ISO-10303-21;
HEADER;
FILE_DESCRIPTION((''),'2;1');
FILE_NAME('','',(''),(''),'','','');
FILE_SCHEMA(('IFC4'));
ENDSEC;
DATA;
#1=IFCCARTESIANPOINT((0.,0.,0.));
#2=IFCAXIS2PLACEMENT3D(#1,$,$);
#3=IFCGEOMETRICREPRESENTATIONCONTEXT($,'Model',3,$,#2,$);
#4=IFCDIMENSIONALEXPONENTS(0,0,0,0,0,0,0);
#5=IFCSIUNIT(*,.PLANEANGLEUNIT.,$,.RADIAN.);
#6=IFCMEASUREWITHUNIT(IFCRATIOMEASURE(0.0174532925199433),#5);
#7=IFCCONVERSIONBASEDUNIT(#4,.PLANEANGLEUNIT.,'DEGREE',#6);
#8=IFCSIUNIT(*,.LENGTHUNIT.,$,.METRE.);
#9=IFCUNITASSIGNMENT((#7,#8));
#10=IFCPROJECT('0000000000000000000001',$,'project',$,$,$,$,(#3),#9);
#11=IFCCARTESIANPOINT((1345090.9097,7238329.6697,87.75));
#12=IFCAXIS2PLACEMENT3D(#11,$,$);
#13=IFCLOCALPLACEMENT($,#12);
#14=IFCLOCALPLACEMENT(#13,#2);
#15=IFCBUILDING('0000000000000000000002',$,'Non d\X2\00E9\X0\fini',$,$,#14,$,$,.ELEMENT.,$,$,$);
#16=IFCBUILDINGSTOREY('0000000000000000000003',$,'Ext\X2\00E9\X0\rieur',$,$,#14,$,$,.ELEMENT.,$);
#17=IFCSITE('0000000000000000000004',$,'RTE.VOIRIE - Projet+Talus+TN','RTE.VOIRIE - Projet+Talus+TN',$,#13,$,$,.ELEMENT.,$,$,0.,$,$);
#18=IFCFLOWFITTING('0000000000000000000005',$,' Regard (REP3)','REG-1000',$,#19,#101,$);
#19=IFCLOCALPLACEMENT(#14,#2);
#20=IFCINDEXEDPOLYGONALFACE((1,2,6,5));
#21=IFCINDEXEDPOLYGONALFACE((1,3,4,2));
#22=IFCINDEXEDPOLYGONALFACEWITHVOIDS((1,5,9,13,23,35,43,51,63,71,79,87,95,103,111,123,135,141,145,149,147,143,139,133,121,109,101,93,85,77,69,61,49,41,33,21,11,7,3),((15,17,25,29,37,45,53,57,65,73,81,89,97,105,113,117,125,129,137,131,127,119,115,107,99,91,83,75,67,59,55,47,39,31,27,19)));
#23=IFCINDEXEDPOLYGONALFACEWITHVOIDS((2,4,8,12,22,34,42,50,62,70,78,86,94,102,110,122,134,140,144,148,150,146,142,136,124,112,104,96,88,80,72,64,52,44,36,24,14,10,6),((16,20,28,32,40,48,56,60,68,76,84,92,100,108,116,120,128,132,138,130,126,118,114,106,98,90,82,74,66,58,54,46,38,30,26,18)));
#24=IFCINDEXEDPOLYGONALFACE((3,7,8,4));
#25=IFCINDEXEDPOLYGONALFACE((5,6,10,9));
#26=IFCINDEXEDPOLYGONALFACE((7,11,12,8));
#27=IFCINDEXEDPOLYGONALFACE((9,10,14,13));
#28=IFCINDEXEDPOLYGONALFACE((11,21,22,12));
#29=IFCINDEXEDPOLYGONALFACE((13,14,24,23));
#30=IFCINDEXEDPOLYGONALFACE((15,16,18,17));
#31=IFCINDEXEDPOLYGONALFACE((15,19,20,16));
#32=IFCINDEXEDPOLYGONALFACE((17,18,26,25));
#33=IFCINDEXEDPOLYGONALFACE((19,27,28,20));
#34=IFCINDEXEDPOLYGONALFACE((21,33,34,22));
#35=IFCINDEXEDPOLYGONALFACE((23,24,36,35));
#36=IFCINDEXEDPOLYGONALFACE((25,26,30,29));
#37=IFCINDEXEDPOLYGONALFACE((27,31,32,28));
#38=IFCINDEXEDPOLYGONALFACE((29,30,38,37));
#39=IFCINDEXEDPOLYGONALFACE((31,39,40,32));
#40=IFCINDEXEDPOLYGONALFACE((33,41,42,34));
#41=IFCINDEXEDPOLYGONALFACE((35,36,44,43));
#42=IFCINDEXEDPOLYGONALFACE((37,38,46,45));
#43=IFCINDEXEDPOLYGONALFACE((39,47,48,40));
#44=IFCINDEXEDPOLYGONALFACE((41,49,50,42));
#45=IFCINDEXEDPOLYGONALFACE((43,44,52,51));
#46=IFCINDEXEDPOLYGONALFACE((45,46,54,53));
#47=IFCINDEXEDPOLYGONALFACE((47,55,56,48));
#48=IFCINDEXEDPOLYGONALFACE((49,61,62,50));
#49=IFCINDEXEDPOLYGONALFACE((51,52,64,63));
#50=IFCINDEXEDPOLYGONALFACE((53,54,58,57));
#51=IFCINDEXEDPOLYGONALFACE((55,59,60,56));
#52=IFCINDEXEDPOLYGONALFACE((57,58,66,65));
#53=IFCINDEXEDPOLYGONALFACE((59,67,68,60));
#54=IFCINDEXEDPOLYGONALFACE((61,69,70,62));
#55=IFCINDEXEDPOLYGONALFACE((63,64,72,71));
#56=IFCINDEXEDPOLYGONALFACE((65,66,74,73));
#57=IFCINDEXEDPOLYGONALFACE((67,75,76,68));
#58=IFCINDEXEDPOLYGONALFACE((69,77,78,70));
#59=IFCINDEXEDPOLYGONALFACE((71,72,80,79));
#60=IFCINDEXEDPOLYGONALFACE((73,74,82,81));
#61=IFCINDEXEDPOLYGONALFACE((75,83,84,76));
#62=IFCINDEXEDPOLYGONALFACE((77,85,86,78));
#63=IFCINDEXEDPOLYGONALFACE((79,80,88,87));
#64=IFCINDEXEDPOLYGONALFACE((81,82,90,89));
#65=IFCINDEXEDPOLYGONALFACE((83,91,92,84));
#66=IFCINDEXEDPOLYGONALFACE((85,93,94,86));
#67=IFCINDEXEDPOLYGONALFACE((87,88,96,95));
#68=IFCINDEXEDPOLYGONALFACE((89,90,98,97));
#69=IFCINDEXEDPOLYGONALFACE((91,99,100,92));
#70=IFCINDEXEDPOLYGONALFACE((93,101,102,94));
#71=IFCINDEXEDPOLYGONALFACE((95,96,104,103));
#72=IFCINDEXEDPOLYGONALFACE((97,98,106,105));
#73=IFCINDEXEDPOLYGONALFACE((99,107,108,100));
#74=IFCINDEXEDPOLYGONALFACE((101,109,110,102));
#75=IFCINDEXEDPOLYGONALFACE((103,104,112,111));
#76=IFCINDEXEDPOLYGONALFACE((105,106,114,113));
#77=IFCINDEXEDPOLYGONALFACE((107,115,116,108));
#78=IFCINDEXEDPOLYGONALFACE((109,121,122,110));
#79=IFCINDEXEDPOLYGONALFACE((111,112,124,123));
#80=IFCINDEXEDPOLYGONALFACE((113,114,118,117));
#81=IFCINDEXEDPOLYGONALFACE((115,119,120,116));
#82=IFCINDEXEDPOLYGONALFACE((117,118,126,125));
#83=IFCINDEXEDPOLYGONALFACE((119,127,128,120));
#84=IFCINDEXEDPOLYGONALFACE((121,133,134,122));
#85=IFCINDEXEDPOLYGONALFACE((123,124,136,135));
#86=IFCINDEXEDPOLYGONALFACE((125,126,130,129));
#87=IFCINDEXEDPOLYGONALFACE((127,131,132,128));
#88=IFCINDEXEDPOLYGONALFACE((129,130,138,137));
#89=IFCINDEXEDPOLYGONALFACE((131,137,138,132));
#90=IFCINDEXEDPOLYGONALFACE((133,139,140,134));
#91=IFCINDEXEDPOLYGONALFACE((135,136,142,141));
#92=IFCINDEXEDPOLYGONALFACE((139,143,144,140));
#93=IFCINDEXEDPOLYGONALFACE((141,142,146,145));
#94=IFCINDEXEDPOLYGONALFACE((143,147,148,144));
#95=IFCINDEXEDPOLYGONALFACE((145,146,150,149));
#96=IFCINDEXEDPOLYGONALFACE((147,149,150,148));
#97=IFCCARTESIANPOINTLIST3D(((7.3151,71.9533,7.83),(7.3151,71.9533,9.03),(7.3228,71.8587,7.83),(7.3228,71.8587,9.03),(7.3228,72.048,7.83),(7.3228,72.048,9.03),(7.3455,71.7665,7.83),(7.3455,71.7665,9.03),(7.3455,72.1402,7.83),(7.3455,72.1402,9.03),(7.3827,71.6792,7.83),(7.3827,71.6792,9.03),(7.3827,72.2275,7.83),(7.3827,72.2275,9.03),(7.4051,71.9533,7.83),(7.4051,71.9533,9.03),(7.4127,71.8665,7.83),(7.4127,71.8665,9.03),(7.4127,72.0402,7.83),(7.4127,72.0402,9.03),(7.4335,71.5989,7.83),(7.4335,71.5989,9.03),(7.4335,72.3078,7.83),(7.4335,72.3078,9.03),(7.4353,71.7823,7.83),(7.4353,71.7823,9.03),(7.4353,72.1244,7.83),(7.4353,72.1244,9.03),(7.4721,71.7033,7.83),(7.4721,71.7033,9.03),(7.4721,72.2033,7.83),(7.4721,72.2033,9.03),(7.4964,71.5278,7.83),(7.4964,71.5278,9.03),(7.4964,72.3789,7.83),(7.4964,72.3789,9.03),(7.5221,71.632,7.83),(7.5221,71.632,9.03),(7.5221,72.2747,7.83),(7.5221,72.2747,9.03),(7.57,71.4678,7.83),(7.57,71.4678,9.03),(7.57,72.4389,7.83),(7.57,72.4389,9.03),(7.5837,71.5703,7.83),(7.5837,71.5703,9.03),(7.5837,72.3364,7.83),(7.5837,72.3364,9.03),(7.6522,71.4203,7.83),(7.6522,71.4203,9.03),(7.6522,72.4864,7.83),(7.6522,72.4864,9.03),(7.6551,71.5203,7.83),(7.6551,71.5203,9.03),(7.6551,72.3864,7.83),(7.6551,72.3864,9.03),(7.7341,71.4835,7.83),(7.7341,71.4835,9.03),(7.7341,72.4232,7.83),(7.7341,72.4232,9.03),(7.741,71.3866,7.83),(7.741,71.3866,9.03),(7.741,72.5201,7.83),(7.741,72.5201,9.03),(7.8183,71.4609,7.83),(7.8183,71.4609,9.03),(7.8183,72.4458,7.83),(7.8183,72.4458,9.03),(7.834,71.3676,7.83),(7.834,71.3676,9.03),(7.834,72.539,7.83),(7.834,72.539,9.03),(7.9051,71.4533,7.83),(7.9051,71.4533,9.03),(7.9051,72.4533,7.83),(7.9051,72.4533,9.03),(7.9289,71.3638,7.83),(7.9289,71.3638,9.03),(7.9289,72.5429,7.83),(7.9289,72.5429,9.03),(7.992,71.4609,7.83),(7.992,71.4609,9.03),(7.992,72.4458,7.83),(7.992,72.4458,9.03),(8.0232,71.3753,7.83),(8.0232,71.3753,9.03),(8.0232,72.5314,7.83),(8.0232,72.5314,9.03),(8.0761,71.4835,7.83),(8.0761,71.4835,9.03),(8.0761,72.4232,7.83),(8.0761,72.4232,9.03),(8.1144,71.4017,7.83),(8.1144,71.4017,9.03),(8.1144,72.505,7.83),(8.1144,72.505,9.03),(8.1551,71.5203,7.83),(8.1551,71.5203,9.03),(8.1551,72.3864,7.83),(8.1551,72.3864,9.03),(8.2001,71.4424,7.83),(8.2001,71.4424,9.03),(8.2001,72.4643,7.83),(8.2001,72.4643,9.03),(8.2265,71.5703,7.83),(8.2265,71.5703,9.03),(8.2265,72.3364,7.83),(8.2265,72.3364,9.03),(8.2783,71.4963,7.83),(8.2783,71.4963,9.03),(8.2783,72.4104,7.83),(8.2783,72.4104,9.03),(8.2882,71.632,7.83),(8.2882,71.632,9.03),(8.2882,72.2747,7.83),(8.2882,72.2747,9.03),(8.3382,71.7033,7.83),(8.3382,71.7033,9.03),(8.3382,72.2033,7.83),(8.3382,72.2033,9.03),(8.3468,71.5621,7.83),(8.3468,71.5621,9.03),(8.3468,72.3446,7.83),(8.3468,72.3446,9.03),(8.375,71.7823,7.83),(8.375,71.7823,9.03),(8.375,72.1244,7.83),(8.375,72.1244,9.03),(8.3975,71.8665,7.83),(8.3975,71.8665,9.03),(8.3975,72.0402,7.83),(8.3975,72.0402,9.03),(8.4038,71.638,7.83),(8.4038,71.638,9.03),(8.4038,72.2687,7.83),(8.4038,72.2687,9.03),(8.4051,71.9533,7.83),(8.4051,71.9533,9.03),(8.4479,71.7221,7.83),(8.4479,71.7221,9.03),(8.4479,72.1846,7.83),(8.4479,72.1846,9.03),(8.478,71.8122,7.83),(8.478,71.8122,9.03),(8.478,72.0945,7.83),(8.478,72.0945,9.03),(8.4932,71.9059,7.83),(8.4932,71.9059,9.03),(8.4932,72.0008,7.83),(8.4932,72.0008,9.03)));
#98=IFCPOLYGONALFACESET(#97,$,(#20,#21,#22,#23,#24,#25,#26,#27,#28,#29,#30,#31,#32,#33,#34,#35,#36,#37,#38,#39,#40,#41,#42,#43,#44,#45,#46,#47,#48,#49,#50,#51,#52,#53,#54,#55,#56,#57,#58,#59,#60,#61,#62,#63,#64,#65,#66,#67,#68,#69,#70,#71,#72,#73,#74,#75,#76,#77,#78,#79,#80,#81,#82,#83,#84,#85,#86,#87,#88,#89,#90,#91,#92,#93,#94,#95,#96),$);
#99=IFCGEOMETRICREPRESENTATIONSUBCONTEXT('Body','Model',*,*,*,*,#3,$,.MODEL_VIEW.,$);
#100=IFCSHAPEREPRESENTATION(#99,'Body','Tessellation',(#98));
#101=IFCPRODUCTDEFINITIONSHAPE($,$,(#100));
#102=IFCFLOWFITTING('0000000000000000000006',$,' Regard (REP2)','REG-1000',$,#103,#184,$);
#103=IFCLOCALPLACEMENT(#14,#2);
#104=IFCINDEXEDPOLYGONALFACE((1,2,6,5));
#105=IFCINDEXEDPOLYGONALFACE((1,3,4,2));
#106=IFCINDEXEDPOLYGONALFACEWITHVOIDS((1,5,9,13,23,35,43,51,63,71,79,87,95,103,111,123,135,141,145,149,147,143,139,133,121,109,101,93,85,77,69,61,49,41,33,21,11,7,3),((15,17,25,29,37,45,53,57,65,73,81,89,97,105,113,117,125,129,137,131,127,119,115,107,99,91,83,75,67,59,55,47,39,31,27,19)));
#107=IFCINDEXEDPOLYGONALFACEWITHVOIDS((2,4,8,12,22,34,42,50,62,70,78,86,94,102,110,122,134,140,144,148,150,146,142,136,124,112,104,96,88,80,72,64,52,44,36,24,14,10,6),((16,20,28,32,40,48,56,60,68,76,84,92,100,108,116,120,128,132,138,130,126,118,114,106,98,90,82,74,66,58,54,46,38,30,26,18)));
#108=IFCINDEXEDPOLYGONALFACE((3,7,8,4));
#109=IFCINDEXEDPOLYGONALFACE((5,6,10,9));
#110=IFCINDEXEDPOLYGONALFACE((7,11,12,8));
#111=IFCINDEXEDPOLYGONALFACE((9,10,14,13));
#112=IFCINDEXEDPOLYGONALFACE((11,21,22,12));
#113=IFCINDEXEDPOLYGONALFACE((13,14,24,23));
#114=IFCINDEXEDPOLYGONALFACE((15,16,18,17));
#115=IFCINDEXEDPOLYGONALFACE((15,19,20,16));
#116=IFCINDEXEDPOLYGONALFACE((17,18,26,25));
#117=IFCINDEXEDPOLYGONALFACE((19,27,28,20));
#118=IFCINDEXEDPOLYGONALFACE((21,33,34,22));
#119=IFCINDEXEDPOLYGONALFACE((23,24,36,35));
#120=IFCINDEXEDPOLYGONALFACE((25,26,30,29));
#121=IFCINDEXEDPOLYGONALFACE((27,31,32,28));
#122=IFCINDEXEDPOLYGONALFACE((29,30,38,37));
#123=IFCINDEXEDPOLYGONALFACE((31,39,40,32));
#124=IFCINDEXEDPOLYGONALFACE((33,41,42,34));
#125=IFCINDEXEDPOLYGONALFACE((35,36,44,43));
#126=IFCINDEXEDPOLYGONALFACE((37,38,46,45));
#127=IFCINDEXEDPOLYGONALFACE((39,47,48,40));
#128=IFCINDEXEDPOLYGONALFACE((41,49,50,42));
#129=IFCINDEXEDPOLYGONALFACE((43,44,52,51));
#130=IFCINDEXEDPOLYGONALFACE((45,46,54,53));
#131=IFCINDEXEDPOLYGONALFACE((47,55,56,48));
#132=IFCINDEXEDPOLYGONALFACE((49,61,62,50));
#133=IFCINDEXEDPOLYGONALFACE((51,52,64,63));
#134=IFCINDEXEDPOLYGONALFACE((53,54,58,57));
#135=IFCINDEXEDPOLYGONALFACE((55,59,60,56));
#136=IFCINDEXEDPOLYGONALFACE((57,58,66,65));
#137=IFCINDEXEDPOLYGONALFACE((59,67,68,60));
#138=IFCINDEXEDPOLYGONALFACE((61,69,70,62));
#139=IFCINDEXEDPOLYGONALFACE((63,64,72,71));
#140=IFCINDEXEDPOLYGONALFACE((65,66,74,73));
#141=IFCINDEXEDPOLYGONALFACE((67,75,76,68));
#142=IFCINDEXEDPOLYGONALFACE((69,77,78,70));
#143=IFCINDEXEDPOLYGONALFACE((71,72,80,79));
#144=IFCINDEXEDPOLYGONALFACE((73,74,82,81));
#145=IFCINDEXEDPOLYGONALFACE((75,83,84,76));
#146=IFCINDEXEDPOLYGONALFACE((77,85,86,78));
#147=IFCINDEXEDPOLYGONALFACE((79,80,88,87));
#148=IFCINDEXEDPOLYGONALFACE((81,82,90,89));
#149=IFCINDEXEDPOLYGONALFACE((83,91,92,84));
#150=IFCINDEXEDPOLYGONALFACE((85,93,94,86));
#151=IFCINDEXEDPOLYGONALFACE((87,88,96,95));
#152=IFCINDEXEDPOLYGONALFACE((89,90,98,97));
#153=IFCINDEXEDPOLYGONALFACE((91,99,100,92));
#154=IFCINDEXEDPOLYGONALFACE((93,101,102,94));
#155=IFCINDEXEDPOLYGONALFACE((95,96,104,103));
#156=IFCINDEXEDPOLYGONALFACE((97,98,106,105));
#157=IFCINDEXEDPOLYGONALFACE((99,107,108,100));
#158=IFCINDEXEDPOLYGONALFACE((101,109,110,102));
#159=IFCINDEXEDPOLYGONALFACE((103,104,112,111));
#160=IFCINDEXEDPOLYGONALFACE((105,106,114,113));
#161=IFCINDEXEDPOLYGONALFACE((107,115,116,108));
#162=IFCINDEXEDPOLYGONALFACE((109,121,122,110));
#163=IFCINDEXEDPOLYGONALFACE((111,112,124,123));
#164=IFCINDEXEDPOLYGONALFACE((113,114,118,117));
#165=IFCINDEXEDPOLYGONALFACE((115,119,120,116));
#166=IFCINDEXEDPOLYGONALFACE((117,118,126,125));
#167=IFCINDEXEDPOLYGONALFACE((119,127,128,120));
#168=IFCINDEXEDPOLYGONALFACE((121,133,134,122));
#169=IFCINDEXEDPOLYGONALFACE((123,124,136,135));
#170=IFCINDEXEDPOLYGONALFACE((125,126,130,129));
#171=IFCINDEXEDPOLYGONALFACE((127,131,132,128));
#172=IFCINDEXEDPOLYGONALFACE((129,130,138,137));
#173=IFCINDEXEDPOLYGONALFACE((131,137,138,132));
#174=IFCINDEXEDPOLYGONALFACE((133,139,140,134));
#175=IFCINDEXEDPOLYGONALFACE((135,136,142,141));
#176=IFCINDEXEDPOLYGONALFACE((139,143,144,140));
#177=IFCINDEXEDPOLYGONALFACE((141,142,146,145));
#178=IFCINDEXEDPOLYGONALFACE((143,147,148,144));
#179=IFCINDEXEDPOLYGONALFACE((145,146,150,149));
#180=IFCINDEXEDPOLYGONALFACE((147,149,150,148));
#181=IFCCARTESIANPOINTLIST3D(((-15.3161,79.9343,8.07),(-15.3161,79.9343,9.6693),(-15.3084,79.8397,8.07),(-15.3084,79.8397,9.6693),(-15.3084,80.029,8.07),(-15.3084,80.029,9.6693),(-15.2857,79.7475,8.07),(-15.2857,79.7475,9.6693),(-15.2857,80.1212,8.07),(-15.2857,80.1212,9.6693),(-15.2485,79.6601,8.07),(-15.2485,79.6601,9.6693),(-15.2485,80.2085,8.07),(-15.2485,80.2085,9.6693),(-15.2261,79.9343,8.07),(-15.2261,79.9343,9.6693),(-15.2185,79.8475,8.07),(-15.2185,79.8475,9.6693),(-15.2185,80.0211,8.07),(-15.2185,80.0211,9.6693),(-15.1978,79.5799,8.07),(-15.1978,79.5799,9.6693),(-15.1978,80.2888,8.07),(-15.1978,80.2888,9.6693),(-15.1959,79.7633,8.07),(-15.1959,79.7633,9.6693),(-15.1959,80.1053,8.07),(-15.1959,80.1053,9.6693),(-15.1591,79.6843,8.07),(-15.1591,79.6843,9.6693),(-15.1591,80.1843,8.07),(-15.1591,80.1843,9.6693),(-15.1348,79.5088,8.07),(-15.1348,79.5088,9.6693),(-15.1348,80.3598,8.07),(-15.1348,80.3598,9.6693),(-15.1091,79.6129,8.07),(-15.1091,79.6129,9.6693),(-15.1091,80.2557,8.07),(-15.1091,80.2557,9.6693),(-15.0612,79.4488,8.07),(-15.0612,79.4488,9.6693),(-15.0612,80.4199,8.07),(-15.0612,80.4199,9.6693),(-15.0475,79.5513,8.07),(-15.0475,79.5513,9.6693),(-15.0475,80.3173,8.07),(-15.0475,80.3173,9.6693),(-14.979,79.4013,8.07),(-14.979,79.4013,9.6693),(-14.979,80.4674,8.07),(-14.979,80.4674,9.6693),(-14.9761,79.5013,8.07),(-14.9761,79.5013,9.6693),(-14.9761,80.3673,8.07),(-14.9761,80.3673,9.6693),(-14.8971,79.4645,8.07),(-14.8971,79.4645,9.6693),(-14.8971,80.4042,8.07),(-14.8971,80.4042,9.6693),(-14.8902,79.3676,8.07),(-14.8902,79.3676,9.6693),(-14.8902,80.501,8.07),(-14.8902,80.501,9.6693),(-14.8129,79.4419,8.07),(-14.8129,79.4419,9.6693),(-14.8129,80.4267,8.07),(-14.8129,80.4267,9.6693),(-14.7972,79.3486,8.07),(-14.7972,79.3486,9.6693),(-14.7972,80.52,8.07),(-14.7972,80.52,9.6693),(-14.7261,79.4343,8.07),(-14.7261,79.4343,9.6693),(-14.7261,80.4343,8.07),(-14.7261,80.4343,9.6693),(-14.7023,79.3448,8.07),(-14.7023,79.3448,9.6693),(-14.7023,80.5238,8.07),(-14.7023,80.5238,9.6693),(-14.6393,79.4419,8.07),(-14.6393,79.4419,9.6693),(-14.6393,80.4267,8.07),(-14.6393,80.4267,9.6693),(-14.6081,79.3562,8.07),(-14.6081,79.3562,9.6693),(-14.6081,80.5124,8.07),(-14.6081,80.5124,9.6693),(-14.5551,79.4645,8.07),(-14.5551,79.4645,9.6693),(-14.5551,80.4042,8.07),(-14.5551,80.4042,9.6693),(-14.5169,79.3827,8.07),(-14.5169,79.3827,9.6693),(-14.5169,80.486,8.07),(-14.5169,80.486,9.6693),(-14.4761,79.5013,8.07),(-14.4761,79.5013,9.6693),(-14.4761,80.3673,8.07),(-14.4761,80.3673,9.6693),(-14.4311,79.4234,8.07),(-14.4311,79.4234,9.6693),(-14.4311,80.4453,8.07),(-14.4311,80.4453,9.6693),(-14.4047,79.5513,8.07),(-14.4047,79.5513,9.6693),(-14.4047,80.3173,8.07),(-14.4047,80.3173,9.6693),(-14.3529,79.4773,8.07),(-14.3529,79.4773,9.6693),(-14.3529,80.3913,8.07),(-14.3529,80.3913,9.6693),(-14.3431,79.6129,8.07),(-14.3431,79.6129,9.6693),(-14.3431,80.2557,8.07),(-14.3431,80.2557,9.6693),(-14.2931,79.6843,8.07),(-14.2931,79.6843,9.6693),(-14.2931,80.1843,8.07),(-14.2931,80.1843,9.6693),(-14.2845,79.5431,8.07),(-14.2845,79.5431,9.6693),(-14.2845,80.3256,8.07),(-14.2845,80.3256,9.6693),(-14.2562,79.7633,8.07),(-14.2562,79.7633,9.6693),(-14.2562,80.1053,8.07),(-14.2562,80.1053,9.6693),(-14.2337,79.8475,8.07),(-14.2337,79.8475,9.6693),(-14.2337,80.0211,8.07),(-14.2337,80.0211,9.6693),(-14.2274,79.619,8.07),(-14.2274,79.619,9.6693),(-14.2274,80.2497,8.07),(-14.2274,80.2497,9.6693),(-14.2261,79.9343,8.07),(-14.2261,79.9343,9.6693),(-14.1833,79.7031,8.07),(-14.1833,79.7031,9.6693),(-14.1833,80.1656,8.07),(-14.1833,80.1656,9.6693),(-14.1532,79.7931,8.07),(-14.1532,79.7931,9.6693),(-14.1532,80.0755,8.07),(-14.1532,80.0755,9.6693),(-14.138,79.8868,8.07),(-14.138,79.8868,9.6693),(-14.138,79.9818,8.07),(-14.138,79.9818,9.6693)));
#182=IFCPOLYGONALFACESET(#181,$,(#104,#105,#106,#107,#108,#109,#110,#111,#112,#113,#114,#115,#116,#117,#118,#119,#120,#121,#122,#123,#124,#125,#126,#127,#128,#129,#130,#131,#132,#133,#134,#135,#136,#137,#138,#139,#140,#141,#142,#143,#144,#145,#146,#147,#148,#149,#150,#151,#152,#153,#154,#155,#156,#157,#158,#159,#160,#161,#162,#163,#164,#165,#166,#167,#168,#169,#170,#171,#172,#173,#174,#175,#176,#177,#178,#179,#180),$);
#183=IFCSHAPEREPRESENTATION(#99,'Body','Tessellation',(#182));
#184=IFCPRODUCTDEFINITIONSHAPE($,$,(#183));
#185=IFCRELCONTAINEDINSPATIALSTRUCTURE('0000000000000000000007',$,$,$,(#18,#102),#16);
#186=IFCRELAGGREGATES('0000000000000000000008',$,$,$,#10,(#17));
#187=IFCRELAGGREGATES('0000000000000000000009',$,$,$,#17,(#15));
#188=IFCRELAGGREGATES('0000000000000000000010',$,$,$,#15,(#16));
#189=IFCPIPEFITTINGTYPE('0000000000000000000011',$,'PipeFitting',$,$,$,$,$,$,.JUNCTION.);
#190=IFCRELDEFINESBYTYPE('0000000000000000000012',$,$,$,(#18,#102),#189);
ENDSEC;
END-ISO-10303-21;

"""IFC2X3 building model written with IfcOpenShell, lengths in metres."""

from ifc_helpers import new_model, entity, si_unit, converted_unit, frame, origin, origin_2d_with_axis, place, context, subcontext, project, spatial, hollow_circle, extrude, type_object, element, save


model = new_model("IFC2X3")

# Units and contexts
model_context = context("Model", 3, world=origin())
body_context = subcontext(model_context, "Body", "Model", "MODEL_VIEW")
ifc_project = project(units=[converted_unit("PLANEANGLEUNIT", "DEGREE", entity("IfcRatioMeasure", 0.0174532925199433), si_unit("PLANEANGLEUNIT", "RADIAN"), dimensions=[0, 0, 0, 0, 0, 0, 0]), si_unit("LENGTHUNIT", "METRE")], contexts=[model_context])

# Site, building, storey
site_placement = place(None, frame((1345090.9097, 7238329.6697, 87.75)))
site = spatial("IfcSite", under=ifc_project, at=site_placement, Name="RTE.VOIRIE - Projet+Talus+TN", Description="RTE.VOIRIE - Projet+Talus+TN", CompositionType="ELEMENT", RefElevation=0.0)
placement = place(site_placement, origin())
building = spatial("IfcBuilding", under=site, at=placement, Name="Non défini", CompositionType="ELEMENT")
storey = spatial("IfcBuildingStorey", under=building, at=placement, Name="Extérieur", CompositionType="ELEMENT")

# Flow fittings
pipe_fitting_type_1 = type_object("IfcPipeFittingType", Name="PipeFitting", PredefinedType="JUNCTION")
flow_fitting_1_placement = place(placement, origin())
element("IfcFlowFitting", 1, at=flow_fitting_1_placement, inside=storey, type_object=pipe_fitting_type_1, Name=" Regard (REP3)", Description="REG-1000", context=body_context, shape_type="SweptSolid", body=[
    extrude(hollow_circle(Radius=0.59, WallThickness=0.09, at=origin_2d_with_axis()), frame((7.9051, 71.9533, 7.83), z_axis=(0.0, 0.0, 1.0), x_axis=(-1.0, 0.0, 0.0)), (0.0, 0.0, 1.0), 1.2),
])
flow_fitting_2_placement = place(placement, origin())
element("IfcFlowFitting", 2, at=flow_fitting_2_placement, inside=storey, type_object=pipe_fitting_type_1, Name=" Regard (REP2)", Description="REG-1000", context=body_context, shape_type="SweptSolid", body=[
    extrude(hollow_circle(Radius=0.59, WallThickness=0.09, at=origin_2d_with_axis()), frame((-14.7261, 79.9343, 8.07), z_axis=(0.0, 0.0, 1.0), x_axis=(-1.0, 0.0, 0.0)), (0.0, 0.0, 1.0), 1.5993),
])

save(model, "model.ifc")
